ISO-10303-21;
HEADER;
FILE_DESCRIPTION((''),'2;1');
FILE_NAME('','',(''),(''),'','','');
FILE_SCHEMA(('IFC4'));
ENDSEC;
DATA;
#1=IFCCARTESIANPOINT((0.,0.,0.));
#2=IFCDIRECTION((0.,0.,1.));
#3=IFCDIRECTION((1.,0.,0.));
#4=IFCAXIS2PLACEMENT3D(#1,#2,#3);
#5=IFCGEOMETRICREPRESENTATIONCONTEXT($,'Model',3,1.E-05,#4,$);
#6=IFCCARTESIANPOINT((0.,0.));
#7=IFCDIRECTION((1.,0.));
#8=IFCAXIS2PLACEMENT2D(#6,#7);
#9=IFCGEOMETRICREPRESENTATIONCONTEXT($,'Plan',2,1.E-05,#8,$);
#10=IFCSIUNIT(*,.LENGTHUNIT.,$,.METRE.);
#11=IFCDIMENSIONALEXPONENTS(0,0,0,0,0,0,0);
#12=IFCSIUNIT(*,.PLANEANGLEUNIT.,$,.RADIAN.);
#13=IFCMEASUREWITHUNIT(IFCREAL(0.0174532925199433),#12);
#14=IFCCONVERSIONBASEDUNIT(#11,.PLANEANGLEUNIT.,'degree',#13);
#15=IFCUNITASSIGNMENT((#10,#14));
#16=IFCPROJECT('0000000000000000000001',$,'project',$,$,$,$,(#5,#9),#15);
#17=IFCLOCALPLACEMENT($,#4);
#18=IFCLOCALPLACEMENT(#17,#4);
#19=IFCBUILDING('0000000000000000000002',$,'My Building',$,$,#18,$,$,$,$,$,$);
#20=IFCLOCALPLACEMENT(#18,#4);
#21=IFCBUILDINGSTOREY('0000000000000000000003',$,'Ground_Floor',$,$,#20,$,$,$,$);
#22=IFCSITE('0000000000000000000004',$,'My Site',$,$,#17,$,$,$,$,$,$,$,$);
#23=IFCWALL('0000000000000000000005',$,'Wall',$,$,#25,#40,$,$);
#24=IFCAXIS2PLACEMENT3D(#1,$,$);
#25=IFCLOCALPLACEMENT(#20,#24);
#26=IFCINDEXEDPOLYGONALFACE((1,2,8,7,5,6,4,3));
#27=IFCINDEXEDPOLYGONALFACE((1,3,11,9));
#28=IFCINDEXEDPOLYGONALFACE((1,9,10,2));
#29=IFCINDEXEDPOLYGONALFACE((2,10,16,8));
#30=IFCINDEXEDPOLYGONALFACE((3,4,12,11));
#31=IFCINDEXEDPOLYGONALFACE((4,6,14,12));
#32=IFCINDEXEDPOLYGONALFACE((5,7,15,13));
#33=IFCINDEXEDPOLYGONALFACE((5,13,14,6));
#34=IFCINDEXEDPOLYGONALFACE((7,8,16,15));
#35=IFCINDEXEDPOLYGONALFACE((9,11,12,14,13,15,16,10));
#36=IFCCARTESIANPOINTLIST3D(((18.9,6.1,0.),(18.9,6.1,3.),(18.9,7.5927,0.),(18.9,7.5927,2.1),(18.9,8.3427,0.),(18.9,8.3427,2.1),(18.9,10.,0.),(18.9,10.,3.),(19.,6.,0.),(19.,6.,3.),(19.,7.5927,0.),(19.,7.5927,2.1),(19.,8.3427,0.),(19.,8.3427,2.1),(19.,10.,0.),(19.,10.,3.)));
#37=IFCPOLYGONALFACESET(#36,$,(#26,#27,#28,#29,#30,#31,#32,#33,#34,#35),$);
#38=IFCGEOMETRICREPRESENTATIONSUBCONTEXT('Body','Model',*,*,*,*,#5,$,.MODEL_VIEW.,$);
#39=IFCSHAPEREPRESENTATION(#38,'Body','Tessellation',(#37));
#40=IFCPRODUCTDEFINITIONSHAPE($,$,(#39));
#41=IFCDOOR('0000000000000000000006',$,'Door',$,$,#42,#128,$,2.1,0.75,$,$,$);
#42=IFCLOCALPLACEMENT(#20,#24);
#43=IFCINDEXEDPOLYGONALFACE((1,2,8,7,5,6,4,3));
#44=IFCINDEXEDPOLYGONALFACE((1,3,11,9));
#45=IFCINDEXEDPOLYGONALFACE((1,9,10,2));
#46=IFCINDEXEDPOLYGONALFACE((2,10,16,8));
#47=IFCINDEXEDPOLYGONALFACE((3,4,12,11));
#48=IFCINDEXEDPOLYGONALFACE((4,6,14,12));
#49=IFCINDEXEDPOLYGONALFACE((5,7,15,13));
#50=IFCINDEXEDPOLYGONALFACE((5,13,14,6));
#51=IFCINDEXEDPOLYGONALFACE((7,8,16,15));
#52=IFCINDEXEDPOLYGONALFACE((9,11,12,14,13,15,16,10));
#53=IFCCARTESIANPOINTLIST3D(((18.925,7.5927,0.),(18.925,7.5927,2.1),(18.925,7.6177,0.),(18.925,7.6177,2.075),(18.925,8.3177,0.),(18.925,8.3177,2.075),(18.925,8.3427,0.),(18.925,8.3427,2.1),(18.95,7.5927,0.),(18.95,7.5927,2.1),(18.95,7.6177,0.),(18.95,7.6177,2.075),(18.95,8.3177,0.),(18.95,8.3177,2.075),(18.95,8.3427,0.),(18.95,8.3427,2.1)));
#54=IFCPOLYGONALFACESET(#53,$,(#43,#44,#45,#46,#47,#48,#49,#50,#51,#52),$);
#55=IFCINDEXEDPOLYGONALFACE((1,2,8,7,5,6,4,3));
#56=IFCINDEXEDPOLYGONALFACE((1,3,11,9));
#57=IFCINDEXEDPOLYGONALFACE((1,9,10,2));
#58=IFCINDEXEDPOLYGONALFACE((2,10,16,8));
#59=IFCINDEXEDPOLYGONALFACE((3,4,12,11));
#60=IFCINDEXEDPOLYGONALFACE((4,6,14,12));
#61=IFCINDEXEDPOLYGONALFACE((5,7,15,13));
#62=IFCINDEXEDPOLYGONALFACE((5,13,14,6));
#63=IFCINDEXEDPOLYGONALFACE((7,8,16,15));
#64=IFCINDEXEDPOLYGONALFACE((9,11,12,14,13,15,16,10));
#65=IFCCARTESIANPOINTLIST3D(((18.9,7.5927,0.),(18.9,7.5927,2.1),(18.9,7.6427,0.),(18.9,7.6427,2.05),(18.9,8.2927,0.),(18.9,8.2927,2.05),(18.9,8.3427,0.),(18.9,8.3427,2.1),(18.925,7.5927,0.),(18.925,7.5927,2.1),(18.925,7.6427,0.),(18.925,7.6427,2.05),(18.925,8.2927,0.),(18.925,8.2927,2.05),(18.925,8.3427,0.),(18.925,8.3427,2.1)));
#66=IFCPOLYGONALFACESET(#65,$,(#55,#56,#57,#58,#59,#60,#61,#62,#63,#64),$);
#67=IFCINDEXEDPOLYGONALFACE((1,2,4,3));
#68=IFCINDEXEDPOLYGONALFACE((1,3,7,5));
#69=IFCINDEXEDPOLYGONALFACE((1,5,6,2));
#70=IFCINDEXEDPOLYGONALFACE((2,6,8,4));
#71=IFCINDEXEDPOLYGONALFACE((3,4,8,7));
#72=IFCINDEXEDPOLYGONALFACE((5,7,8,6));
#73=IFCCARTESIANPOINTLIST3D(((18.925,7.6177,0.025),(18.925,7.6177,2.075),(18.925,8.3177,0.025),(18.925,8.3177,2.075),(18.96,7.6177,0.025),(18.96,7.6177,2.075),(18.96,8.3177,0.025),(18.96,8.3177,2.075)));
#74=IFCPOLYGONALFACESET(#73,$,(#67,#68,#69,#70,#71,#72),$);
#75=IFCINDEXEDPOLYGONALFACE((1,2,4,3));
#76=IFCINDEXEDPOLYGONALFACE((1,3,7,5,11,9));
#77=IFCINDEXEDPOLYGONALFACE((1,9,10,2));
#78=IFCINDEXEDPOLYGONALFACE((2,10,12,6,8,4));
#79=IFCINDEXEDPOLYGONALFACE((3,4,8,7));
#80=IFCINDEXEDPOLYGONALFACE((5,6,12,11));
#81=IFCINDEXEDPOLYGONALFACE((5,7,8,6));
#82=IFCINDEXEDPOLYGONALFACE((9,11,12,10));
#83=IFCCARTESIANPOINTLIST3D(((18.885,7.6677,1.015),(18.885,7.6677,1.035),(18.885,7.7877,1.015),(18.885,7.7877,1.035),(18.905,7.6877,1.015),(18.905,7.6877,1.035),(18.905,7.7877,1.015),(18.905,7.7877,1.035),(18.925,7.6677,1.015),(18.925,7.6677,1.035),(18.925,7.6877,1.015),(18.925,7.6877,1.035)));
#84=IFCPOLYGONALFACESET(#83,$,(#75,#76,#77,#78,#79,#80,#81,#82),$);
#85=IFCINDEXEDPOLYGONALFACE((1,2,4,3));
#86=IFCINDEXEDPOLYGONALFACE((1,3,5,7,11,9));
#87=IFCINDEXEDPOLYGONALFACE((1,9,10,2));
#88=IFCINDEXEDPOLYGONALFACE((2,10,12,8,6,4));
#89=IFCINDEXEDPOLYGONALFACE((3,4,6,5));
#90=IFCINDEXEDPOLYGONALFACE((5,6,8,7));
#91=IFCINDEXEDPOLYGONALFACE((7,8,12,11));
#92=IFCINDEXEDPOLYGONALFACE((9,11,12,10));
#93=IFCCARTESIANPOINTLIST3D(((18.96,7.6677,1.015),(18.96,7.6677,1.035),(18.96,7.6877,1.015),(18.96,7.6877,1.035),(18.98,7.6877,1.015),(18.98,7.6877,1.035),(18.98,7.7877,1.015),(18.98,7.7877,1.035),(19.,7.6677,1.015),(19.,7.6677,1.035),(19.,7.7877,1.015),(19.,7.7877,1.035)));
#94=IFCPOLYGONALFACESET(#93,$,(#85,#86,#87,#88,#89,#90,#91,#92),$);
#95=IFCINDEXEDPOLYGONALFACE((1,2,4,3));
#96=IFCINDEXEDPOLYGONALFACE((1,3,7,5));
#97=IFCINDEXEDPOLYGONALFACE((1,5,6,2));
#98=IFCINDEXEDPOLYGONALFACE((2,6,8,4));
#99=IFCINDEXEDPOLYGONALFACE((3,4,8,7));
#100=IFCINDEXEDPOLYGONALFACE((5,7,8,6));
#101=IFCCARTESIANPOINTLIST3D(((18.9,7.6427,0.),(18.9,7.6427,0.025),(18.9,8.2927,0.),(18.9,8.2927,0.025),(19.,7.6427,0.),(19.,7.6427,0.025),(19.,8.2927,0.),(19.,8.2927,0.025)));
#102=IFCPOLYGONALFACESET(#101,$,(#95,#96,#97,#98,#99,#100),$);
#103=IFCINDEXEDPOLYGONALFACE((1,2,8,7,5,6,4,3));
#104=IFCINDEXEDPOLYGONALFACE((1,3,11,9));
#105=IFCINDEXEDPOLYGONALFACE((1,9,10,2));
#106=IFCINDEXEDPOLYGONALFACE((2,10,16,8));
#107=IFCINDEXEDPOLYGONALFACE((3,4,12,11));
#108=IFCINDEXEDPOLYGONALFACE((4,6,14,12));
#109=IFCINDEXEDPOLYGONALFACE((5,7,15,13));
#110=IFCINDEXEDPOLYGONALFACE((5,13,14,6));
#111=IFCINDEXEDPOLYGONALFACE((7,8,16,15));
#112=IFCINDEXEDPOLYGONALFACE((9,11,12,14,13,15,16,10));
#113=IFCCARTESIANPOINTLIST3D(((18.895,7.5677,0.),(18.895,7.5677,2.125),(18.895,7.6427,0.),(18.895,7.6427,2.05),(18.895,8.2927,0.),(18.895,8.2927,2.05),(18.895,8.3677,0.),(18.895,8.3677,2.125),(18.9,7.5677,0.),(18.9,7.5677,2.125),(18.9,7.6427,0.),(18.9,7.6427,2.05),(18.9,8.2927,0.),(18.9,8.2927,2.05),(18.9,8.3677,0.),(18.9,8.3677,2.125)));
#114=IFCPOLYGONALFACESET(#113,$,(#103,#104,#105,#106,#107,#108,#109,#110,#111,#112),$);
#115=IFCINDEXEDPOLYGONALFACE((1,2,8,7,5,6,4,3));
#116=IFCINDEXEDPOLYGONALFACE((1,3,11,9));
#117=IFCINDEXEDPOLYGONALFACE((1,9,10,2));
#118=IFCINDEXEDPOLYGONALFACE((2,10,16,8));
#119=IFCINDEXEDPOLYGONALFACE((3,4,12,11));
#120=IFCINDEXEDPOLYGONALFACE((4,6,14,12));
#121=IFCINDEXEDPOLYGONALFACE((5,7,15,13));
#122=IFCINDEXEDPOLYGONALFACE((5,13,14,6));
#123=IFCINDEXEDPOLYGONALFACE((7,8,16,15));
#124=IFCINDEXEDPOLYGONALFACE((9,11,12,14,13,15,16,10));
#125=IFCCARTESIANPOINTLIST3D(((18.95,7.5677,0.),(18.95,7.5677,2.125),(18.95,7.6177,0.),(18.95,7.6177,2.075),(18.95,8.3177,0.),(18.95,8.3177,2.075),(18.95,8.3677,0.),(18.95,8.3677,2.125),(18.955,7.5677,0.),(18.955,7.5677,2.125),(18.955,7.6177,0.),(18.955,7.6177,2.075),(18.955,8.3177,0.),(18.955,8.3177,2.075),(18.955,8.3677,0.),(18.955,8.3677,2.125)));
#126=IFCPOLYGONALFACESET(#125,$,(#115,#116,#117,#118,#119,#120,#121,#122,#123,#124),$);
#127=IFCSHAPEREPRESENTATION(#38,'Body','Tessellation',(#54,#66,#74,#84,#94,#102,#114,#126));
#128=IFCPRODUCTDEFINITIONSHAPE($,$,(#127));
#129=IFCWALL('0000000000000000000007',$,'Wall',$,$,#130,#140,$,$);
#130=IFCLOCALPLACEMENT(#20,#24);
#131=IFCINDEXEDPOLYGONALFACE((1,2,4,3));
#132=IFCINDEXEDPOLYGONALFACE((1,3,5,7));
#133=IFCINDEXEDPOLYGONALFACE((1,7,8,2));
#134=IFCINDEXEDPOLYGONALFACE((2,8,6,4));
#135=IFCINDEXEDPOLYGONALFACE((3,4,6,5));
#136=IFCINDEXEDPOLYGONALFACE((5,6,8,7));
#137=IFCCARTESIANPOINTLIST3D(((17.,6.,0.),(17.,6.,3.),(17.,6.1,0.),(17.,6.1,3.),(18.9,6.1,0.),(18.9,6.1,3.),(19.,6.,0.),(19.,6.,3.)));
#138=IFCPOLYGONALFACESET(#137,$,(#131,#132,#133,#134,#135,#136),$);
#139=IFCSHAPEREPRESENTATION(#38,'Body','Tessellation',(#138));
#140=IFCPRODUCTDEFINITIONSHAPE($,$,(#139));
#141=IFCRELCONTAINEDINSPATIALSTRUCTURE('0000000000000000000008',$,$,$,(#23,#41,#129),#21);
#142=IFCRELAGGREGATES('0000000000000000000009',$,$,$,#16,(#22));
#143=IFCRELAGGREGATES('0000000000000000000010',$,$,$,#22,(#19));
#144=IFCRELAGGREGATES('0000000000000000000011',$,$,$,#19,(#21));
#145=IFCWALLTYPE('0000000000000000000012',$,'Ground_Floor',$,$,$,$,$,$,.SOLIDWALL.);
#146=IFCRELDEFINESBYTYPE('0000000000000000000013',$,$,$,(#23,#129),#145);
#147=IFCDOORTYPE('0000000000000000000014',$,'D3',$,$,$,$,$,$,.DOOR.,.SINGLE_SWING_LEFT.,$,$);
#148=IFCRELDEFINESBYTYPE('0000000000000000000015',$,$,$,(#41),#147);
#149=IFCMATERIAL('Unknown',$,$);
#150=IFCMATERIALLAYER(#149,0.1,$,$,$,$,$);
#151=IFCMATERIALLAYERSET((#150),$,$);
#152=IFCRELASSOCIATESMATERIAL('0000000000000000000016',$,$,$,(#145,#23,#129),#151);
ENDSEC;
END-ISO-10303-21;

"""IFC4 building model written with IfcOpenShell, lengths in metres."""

from ifc_helpers import new_model, entity, si_unit, converted_unit, frame, origin_with_axes, origin_2d_with_axis, place, context, subcontext, project, spatial, line, indexed_curve, outline, extrude, shape, source, transform, mapped, material, layer, layer_set, layer_usage, type_object, type_shapes, element, fill, save


model = new_model("IFC4")

# Units and contexts
model_context = context("Model", 3, precision=1e-05, world=origin_with_axes())
plan_context = context("Plan", 2, precision=1e-05, world=origin_2d_with_axis())
body_context_1 = subcontext(model_context, "Body", "Model", "MODEL_VIEW")
body_context_2 = subcontext(plan_context, "Body", "Plan", "PLAN_VIEW")
ifc_project = project(units=[si_unit("LENGTHUNIT", "METRE"), converted_unit("PLANEANGLEUNIT", "degree", entity("IfcReal", 0.0174532925199433), si_unit("PLANEANGLEUNIT", "RADIAN"), dimensions=[0, 0, 0, 0, 0, 0, 0])], contexts=[model_context, plan_context])

# Site, building, storey
site_placement = place(None, origin_with_axes())
site = spatial("IfcSite", under=ifc_project, at=site_placement, Name="My Site")
building_placement = place(site_placement, origin_with_axes())
building = spatial("IfcBuilding", under=site, at=building_placement, Name="My Building")
storey_placement = place(building_placement, origin_with_axes())
storey = spatial("IfcBuildingStorey", under=building, at=storey_placement, Name="Ground_Floor")

# Shared definitions
ifc_material = material(Name="Unknown")

# Shared definitions
ifc_layer = layer(ifc_material, 0.1)
ifc_layer_set = layer_set([ifc_layer])
wall_type = type_object("IfcWallType", Name="Ground_Floor", PredefinedType="SOLIDWALL", material=ifc_layer_set)

# Shared definitions
shared_shape_1 = source(origin_with_axes(), body_context_1, "Body", "SweptSolid", [
    extrude(outline(indexed_curve([(0.0, 0.0), (0.75, 0.0), (0.75, 2.1), (0.0, 2.1)], segments=[line(1, 2, 3, 4, 1)])), frame((0.0, -0.6, 0.0), z_axis=(0.0, -1.0, 0.0), x_axis=(1.0, 0.0, 0.0)), (0.0, 0.0, -1.0), 1.2),
])
door_type_1 = type_object("IfcDoorType", Name="D3", OperationType="SINGLE_SWING_LEFT", PredefinedType="DOOR")
shared_shape_2 = source(origin_with_axes(), body_context_1, "Body", "SweptSolid", [
    extrude(outline(indexed_curve([(0.0, 0.0), (0.0, 2.1), (0.75, 2.1), (0.75, 0.0), (0.725, 0.0), (0.725, 2.075), (0.025, 2.075), (0.025, 0.0)], segments=[line(1, 2, 3, 4, 5, 6, 7, 8, 1)])), frame((0.0, 0.025, 0.0), z_axis=(0.0, -1.0, 0.0), x_axis=(1.0, 0.0, 0.0)), (0.0, 0.0, -1.0), 0.025),
    extrude(outline(indexed_curve([(0.0, 0.0), (0.0, 2.1), (0.75, 2.1), (0.75, 0.0), (0.7, 0.0), (0.7, 2.05), (0.05, 2.05), (0.05, 0.0)], segments=[line(1, 2, 3, 4, 5, 6, 7, 8, 1)])), frame((0.0, 0.0, 0.0), z_axis=(0.0, -1.0, 0.0), x_axis=(1.0, 0.0, 0.0)), (0.0, 0.0, -1.0), 0.025),
    extrude(outline(indexed_curve([(0.0, 0.0), (0.7, 0.0), (0.7, 0.035), (0.0, 0.035)], segments=[line(1, 2, 3, 4, 1)])), frame((0.025, 0.025, 0.025), z_axis=(0.0, 0.0, 1.0), x_axis=(1.0, 0.0, 0.0)), (0.0, 0.0, 1.0), 2.05),
    extrude(outline(indexed_curve([(0.0, 0.0), (0.0, -0.04), (-0.12, -0.04), (-0.12, -0.02), (-0.02, -0.02), (-0.02, 0.0)], segments=[line(1, 2, 3, 4, 5, 6, 1)])), frame((0.675, 0.025, 1.015), z_axis=(0.0, 0.0, 1.0), x_axis=(1.0, 0.0, 0.0)), (0.0, 0.0, 1.0), 0.02),
    extrude(outline(indexed_curve([(0.0, 0.0), (0.0, 0.04), (-0.12, 0.04), (-0.12, 0.02), (-0.02, 0.02), (-0.02, 0.0)], segments=[line(1, 2, 3, 4, 5, 6, 1)])), frame((0.675, 0.06, 1.015), z_axis=(0.0, 0.0, 1.0), x_axis=(1.0, 0.0, 0.0)), (0.0, 0.0, 1.0), 0.02),
    extrude(outline(indexed_curve([(0.0, 0.0), (0.65, 0.0), (0.65, 0.1), (0.0, 0.1)], segments=[line(1, 2, 3, 4, 1)])), frame((0.05, 0.0, 0.0), z_axis=(0.0, 0.0, 1.0), x_axis=(1.0, 0.0, 0.0)), (0.0, 0.0, 1.0), 0.025),
    extrude(outline(indexed_curve([(0.0, 0.0), (0.0, 2.125), (0.8, 2.125), (0.8, 0.0), (0.725, 0.0), (0.725, 2.05), (0.075, 2.05), (0.075, 0.0)], segments=[line(1, 2, 3, 4, 5, 6, 7, 8, 1)])), frame((-0.025, -0.005, 0.0), z_axis=(0.0, -1.0, 0.0), x_axis=(1.0, 0.0, 0.0)), (0.0, 0.0, -1.0), 0.005),
    extrude(outline(indexed_curve([(0.0, 0.0), (0.0, 2.125), (0.8, 2.125), (0.8, 0.0), (0.75, 0.0), (0.75, 2.075), (0.05, 2.075), (0.05, 0.0)], segments=[line(1, 2, 3, 4, 5, 6, 7, 8, 1)])), frame((-0.025, 0.05, 0.0), z_axis=(0.0, -1.0, 0.0), x_axis=(1.0, 0.0, 0.0)), (0.0, 0.0, -1.0), 0.005),
])
shared_shape_3 = source(origin_with_axes(), body_context_2, "Body", "Curve2D", [
    entity("IfcIndexedPolyCurve", entity("IfcCartesianPointList2D", [[0.0, 0.0], [0.0, 0.05], [0.025, 0.05], [0.025, 0.025], [0.05, 0.025], [0.05, 0.0]]), [entity("IfcLineIndex", [1, 2, 3, 4, 5, 6, 1])]),
    entity("IfcIndexedPolyCurve", entity("IfcCartesianPointList2D", [[0.75, 0.0], [0.75, 0.05], [0.725, 0.05], [0.725, 0.025], [0.7, 0.025], [0.7, 0.0]]), [entity("IfcLineIndex", [1, 2, 3, 4, 5, 6, 1])]),
    entity("IfcTrimmedCurve", entity("IfcEllipse", entity("IfcAxis2Placement2D", entity("IfcCartesianPoint", [0.06, 0.05]), entity("IfcDirection", [1.0, 0.0])), 0.665, 0.7), [entity("IfcCartesianPoint", [0.725, 0.05])], [entity("IfcCartesianPoint", [0.06, 0.75])], True, "CARTESIAN"),
    entity("IfcIndexedPolyCurve", entity("IfcCartesianPointList2D", [[0.025, 0.05], [0.06, 0.05], [0.06, 0.75], [0.025, 0.75]]), [entity("IfcLineIndex", [1, 2, 3, 4, 1])]),
])
type_shapes(door_type_1, [shared_shape_2, shared_shape_3])

# Wall, opening, door
ifc_layer_usage_1 = layer_usage(ifc_layer_set, "AXIS2", "POSITIVE", 0.0)
wall_1_placement = place(storey_placement, frame((19.0, 6.0, 0.0), z_axis=(0.0, 0.0, 1.0), x_axis=(0.0, 1.0, 0.0)))
wall_1 = element("IfcWall", 1, at=wall_1_placement, inside=storey, type_object=wall_type, material=ifc_layer_usage_1, Name="Wall", context=body_context_1, shape_type="SweptSolid", body=[
    extrude(outline(indexed_curve([(0.0, 0.0), (0.1, 0.1), (4.0, 0.1), (4.0, 0.0)], segments=[line(1, 2, 3, 4, 1)])), origin_with_axes(), (0.0, 0.0, 1.0), 3.0),
])
opening_1_placement = place(wall_1_placement, frame((2.3427, 0.1, 0.0), z_axis=(0.0, 0.0, 1.0), x_axis=(-1.0, 0.0, 0.0)))
opening_1 = element("IfcOpeningElement", 2, at=opening_1_placement, cuts=wall_1, PredefinedType="OPENING", context=body_context_1, shape_type="MappedRepresentation", body=[
    mapped(shared_shape_1, transform((0.0, 0.0, 0.0), x_axis=(1.0, 0.0, 0.0), y_axis=(0.0, 1.0, 0.0), z_axis=(0.0, 0.0, 1.0), scale=1.0)),
])
door_1_placement = place(opening_1_placement, frame((0.0, 0.0, 0.0), z_axis=(0.0, 0.0, 1.0), x_axis=(1.0, 0.0, 0.0)))
door_1 = element("IfcDoor", 3, at=door_1_placement, inside=storey, type_object=door_type_1, Name="Door", OverallHeight=2.1, OverallWidth=0.75, shapes=[
    shape(body_context_1, "Body", "MappedRepresentation", [mapped(shared_shape_2, transform((0.0, 0.0, 0.0), x_axis=(1.0, 0.0, 0.0), y_axis=(0.0, 1.0, 0.0), z_axis=(0.0, 0.0, 1.0), scale=1.0))]),
    shape(body_context_2, "Body", "MappedRepresentation", [mapped(shared_shape_3, transform((0.0, 0.0, 0.0), x_axis=(1.0, 0.0, 0.0), y_axis=(0.0, 1.0, 0.0), z_axis=(0.0, 0.0, 1.0), scale=1.0))]),
])
fill(opening_1, door_1)

# Wall
ifc_layer_usage_2 = layer_usage(ifc_layer_set, "AXIS2", "POSITIVE", 0.0)
wall_2_placement = place(storey_placement, frame((17.0, 6.0, 0.0), z_axis=(0.0, 0.0, 1.0), x_axis=(1.0, 0.0, 0.0)))
element("IfcWall", 4, at=wall_2_placement, inside=storey, type_object=wall_type, material=ifc_layer_usage_2, Name="Wall", context=body_context_1, shape_type="SweptSolid", body=[
    extrude(outline(indexed_curve([(0.0, 0.0), (0.0, 0.1), (1.9, 0.1), (2.0, 0.0)], segments=[line(1, 2, 3, 4, 1)])), origin_with_axes(), (0.0, 0.0, 1.0), 3.0),
])

save(model, "model.ifc")
